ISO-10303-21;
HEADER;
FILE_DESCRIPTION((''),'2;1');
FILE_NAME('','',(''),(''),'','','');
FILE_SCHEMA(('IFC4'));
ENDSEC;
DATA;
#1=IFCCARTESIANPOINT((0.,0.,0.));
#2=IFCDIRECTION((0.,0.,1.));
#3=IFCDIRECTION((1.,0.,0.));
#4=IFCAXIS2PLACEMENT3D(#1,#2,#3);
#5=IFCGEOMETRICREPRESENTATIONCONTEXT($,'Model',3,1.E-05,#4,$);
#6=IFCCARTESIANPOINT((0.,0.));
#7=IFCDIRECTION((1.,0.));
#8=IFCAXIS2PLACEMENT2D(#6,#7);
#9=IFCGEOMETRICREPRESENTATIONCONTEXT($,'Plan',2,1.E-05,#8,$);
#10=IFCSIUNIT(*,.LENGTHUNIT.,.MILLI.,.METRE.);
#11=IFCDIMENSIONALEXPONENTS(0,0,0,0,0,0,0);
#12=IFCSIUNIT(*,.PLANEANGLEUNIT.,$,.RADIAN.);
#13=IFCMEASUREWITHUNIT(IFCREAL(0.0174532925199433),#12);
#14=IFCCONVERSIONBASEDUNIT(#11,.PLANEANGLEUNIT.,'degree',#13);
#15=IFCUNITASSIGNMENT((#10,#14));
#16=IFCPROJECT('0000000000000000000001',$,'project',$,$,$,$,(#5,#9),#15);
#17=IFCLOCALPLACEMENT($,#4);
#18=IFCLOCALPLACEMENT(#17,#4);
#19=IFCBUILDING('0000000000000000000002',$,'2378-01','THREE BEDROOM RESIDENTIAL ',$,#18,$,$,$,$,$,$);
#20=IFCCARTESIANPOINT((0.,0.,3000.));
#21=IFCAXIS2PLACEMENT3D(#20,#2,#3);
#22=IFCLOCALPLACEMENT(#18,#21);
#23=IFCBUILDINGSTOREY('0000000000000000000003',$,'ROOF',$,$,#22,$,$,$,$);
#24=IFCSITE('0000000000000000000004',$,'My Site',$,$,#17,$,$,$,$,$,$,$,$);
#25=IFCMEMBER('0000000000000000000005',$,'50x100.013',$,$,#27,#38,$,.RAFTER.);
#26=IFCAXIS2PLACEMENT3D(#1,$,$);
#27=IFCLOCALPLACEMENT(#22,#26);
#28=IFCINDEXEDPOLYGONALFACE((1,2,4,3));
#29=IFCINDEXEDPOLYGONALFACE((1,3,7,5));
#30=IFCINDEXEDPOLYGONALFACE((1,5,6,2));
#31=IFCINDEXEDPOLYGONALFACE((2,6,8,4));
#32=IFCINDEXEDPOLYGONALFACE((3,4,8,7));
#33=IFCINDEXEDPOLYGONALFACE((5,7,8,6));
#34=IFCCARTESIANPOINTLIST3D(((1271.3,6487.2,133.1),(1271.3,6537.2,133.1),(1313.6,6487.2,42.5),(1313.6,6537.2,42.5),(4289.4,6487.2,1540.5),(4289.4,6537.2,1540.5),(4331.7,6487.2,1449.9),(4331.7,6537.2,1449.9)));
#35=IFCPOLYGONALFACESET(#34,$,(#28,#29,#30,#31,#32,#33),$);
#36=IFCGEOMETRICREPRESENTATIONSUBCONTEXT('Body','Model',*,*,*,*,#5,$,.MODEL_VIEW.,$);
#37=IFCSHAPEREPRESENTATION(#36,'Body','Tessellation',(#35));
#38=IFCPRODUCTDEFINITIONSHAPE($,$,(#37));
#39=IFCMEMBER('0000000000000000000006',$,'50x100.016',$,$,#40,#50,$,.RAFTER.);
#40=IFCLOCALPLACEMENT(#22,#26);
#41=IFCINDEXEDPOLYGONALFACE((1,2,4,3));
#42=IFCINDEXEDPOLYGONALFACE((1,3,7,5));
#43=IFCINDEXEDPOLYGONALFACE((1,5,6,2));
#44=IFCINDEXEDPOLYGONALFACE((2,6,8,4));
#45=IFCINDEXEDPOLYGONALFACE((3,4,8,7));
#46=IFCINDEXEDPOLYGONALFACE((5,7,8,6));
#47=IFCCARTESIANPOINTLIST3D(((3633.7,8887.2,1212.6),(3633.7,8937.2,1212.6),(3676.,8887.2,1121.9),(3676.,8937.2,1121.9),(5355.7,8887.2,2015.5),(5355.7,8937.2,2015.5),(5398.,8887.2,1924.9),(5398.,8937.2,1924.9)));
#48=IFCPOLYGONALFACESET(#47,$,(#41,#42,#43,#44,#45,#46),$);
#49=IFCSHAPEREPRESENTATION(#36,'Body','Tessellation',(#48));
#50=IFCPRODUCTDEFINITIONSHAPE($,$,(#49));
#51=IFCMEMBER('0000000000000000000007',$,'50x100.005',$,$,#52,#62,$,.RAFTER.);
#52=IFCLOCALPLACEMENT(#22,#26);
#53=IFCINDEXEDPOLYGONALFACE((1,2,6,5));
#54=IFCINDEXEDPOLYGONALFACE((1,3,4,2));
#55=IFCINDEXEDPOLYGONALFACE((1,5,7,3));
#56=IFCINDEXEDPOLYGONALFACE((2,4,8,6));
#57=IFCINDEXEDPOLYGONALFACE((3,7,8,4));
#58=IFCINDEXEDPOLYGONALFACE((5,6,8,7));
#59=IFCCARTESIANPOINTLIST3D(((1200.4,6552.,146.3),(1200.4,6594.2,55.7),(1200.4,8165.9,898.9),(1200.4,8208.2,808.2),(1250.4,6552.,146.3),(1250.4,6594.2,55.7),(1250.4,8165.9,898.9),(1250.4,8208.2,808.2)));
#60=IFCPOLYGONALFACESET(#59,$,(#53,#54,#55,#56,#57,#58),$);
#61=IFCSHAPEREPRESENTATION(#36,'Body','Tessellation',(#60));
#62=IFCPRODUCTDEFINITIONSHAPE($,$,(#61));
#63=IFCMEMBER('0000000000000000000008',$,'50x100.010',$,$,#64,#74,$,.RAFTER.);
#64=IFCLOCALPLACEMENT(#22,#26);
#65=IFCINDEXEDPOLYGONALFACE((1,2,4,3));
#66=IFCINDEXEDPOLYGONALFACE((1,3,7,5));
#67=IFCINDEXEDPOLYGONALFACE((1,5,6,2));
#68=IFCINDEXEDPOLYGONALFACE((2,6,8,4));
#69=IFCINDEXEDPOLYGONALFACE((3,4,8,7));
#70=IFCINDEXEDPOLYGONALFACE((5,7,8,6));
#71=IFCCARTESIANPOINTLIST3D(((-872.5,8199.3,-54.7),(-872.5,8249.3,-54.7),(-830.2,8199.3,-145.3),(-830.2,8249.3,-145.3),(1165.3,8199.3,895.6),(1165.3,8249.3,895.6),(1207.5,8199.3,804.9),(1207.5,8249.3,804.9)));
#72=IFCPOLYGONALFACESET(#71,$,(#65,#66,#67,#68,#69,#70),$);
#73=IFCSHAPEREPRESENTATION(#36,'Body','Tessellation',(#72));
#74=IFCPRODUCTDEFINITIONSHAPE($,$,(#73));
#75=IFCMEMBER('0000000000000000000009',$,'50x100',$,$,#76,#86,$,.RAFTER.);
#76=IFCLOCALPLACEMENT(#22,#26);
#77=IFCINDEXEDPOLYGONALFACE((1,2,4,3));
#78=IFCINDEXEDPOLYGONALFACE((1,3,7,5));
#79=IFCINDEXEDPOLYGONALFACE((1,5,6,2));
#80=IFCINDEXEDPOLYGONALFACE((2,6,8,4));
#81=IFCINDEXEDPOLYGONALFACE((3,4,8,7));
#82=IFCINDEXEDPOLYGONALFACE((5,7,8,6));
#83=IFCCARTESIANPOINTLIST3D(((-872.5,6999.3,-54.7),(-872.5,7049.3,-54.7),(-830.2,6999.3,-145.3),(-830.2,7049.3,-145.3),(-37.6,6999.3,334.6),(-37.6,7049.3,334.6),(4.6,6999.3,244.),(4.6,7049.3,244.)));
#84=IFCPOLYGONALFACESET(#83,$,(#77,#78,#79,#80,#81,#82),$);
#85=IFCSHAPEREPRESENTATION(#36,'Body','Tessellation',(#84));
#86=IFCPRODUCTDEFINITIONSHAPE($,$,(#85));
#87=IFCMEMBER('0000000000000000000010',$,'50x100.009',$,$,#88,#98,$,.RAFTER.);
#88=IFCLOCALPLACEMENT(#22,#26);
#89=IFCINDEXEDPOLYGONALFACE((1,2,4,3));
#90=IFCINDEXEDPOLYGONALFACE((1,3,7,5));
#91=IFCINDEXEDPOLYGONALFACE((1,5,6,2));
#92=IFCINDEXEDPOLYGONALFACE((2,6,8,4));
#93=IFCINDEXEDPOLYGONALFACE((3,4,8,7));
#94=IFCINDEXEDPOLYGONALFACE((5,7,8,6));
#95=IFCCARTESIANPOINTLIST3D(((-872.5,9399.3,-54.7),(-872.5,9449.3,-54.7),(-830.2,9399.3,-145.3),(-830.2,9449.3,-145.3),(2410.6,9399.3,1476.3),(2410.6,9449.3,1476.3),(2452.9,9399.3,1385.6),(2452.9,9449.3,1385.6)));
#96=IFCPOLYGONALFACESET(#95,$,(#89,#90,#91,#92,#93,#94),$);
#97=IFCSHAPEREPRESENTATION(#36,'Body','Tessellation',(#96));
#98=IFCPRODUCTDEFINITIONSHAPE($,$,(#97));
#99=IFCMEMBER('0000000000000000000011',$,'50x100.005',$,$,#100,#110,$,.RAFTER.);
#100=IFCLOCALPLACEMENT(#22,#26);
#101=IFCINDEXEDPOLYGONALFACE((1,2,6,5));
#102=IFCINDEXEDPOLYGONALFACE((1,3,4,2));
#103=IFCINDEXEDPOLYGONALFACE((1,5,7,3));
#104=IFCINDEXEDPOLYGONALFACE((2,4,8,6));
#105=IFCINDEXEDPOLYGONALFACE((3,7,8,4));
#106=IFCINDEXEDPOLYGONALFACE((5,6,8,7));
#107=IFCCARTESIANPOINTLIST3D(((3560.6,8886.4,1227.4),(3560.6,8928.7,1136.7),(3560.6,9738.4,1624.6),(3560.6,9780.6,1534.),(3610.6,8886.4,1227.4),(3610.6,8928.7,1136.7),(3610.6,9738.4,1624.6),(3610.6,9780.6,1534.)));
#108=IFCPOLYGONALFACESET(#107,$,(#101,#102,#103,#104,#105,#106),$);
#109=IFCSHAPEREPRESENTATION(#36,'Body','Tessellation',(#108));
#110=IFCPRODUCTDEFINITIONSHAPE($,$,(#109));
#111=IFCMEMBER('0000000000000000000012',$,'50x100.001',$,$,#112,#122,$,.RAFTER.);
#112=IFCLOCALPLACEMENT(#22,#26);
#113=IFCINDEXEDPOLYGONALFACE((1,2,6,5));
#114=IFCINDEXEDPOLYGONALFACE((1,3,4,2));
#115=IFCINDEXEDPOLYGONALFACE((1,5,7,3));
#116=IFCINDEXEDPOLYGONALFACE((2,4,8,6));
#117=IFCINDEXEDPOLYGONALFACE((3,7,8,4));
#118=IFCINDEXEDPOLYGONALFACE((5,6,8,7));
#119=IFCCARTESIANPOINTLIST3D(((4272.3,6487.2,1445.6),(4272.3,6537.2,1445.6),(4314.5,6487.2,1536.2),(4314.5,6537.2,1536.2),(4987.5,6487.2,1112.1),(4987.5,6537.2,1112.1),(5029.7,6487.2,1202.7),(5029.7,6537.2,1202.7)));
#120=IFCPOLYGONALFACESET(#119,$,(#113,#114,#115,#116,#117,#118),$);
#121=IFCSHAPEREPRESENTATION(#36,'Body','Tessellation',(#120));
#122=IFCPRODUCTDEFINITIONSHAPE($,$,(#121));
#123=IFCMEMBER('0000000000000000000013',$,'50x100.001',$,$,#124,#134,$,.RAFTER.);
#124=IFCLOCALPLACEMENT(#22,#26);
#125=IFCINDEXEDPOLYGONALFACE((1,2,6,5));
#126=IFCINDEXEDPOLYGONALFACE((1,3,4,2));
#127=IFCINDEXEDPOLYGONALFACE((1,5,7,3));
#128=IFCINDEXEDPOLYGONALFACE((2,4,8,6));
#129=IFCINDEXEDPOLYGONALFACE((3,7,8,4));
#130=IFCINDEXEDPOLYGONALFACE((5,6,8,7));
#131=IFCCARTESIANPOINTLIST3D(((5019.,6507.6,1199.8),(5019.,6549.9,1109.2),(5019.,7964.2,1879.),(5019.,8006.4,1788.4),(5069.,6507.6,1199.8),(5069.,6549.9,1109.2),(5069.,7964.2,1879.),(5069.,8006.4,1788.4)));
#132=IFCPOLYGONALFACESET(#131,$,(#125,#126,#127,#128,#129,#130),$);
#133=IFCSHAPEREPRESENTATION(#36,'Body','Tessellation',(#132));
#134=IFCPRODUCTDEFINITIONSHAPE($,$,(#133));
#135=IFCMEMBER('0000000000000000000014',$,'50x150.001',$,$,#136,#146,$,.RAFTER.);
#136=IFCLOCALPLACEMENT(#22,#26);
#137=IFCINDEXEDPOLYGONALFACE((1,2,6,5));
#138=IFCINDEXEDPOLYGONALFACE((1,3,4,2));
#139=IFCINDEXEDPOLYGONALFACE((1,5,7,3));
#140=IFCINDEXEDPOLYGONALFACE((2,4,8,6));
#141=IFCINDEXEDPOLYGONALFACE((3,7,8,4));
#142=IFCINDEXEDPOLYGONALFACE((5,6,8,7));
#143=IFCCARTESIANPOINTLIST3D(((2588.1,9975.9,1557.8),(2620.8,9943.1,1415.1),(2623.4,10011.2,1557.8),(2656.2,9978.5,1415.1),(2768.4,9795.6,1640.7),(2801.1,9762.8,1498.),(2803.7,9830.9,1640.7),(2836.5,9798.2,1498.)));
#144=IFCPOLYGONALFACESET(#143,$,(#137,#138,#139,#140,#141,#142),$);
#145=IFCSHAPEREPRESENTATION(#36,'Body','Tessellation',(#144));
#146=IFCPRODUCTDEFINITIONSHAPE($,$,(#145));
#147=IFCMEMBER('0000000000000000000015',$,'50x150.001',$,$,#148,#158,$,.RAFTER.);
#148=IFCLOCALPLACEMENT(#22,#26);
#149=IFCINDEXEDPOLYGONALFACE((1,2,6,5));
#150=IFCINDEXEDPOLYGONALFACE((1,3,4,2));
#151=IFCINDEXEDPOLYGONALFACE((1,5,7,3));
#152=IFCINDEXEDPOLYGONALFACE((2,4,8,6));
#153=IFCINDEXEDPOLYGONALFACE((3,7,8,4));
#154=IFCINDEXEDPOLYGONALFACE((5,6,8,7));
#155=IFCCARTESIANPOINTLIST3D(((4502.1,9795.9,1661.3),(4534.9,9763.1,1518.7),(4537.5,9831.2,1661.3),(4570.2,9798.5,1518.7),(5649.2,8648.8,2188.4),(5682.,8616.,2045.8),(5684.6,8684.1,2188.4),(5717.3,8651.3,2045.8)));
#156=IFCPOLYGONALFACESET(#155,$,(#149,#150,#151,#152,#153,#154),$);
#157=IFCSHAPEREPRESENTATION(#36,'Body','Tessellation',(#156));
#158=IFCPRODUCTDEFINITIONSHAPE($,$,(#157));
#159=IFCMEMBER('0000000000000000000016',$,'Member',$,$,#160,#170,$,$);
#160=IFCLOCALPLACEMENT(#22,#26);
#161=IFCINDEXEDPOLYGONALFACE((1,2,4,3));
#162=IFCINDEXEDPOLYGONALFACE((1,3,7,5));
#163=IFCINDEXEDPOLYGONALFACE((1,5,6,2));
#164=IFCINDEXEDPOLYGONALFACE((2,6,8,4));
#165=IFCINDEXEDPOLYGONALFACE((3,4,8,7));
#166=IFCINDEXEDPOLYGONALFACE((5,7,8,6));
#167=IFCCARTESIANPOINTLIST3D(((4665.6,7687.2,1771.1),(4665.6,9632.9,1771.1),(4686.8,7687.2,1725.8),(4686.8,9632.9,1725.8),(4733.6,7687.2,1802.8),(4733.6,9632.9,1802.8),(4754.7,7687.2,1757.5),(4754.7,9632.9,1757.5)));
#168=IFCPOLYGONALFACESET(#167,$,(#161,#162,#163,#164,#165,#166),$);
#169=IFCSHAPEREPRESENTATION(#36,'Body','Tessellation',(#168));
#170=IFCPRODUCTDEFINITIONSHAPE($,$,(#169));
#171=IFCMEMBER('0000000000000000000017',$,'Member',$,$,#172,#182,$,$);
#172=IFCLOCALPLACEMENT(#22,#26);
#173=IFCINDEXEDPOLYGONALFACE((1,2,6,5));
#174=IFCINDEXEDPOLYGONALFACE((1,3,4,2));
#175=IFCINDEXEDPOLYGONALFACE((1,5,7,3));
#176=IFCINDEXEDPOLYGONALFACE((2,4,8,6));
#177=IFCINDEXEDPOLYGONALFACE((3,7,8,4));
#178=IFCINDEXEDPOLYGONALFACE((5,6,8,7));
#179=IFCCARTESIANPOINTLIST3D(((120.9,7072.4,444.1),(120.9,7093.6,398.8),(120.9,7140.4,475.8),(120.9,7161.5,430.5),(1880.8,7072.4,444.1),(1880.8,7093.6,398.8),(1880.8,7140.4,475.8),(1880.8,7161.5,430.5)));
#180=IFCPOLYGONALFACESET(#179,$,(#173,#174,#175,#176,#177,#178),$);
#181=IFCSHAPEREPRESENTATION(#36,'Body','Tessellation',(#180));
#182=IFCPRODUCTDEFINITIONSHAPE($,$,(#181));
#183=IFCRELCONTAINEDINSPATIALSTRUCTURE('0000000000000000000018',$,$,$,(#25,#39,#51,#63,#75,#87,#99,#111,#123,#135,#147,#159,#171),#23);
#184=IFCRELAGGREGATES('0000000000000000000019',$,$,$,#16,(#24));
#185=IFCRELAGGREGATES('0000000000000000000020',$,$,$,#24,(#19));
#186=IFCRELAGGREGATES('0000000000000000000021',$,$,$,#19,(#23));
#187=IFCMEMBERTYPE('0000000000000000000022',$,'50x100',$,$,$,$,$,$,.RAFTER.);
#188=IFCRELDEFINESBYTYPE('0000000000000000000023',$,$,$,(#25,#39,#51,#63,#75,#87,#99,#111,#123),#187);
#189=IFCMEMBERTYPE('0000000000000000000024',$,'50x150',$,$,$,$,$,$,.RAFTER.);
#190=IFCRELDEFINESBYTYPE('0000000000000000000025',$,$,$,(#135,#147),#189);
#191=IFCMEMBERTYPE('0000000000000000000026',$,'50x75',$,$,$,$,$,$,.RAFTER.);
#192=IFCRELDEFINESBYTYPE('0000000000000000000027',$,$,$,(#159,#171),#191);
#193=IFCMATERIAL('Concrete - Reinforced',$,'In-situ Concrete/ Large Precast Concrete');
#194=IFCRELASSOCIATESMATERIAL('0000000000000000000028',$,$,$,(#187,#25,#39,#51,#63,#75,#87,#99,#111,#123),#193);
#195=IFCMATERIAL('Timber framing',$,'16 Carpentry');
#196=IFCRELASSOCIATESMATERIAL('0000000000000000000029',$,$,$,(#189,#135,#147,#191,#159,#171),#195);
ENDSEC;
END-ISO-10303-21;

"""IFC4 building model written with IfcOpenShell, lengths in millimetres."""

from ifc_helpers import new_model, entity, si_unit, converted_unit, frame, origin_with_axes, origin_2d_with_axis, place, context, subcontext, project, spatial, rectangle, extrude, material, material_profile, profile_set, profile_usage, type_object, element, save


model = new_model("IFC4")

# Units and contexts
model_context = context("Model", 3, precision=1e-05, world=origin_with_axes())
plan_context = context("Plan", 2, precision=1e-05, world=origin_2d_with_axis())
body_context = subcontext(model_context, "Body", "Model", "MODEL_VIEW")
ifc_project = project(units=[si_unit("LENGTHUNIT", "METRE", prefix="MILLI"), converted_unit("PLANEANGLEUNIT", "degree", entity("IfcReal", 0.0174532925199433), si_unit("PLANEANGLEUNIT", "RADIAN"), dimensions=[0, 0, 0, 0, 0, 0, 0])], contexts=[model_context, plan_context])

# Site, building, storey
site_placement = place(None, origin_with_axes())
site = spatial("IfcSite", under=ifc_project, at=site_placement, Name="My Site")
building_placement = place(site_placement, origin_with_axes())
building = spatial("IfcBuilding", under=site, at=building_placement, Name="2378-01", Description="THREE BEDROOM RESIDENTIAL ")
storey_placement = place(building_placement, frame((0.0, 0.0, 3000.0), z_axis=(0.0, 0.0, 1.0), x_axis=(1.0, 0.0, 0.0)))
storey = spatial("IfcBuildingStorey", under=building, at=storey_placement, Name="ROOF")

# Members
ifc_material_1 = material(Name="Concrete - Reinforced", Category="In-situ Concrete/ Large Precast Concrete")
ifc_material_profile_1 = material_profile(ifc_material_1, rectangle(XDim=50.0, YDim=100.0), Name="Core Layer", Category="LoadBearing", Priority=1)
ifc_profile_set_1 = profile_set([ifc_material_profile_1], Name="wood")
ifc_profile_usage_1 = profile_usage(ifc_profile_set_1)
member_type_1 = type_object("IfcMemberType", Name="50x100", PredefinedType="RAFTER", material=ifc_profile_set_1)
member_1_placement = place(storey_placement, frame((1292.4, 6512.2, 87.8), z_axis=(0.906308, 0.0, 0.422618), x_axis=(0.0, 1.0, 0.0)))
element("IfcMember", 1, at=member_1_placement, inside=storey, type_object=member_type_1, material=ifc_profile_usage_1, Name="50x100.013", PredefinedType="RAFTER", context=body_context, shape_type="SweptSolid", body=[
    extrude(rectangle(XDim=50.0, YDim=100.0), origin_with_axes(), (0.0, 0.0, 1.0), 3330.1),
])
ifc_profile_usage_2 = profile_usage(ifc_profile_set_1)
member_2_placement = place(storey_placement, frame((3654.9, 8912.2, 1167.2), z_axis=(0.906308, 0.0, 0.422618), x_axis=(0.0, 1.0, 0.0)))
element("IfcMember", 2, at=member_2_placement, inside=storey, type_object=member_type_1, material=ifc_profile_usage_2, Name="50x100.016", PredefinedType="RAFTER", context=body_context, shape_type="SweptSolid", body=[
    extrude(rectangle(XDim=50.0, YDim=100.0), origin_with_axes(), (0.0, 0.0, 1.0), 1900.0),
])
ifc_profile_usage_3 = profile_usage(ifc_profile_set_1)
member_3_placement = place(storey_placement, frame((1225.4, 6573.1, 101.0), z_axis=(0.0, 0.906308, 0.422618), x_axis=(-1.0, 0.0, 0.0)))
element("IfcMember", 3, at=member_3_placement, inside=storey, type_object=member_type_1, material=ifc_profile_usage_3, Name="50x100.005", PredefinedType="RAFTER", context=body_context, shape_type="SweptSolid", body=[
    extrude(rectangle(XDim=50.0, YDim=100.0), origin_with_axes(), (0.0, 0.0, 1.0), 1780.8),
])
ifc_profile_usage_4 = profile_usage(ifc_profile_set_1)
member_4_placement = place(storey_placement, frame((-851.4, 8224.3, -100.0), z_axis=(0.906308, 0.0, 0.422618), x_axis=(0.0, 1.0, 0.0)))
element("IfcMember", 4, at=member_4_placement, inside=storey, type_object=member_type_1, material=ifc_profile_usage_4, Name="50x100.010", PredefinedType="RAFTER", context=body_context, shape_type="SweptSolid", body=[
    extrude(rectangle(XDim=50.0, YDim=100.0), origin_with_axes(), (0.0, 0.0, 1.0), 2248.4),
])
ifc_profile_usage_5 = profile_usage(ifc_profile_set_1)
member_5_placement = place(storey_placement, frame((-851.4, 7024.3, -100.0), z_axis=(0.906308, 0.0, 0.422618), x_axis=(0.0, 1.0, 0.0)))
element("IfcMember", 5, at=member_5_placement, inside=storey, type_object=member_type_1, material=ifc_profile_usage_5, Name="50x100", PredefinedType="RAFTER", context=body_context, shape_type="SweptSolid", body=[
    extrude(rectangle(XDim=50.0, YDim=100.0), origin_with_axes(), (0.0, 0.0, 1.0), 921.2),
])
ifc_profile_usage_6 = profile_usage(ifc_profile_set_1)
member_6_placement = place(storey_placement, frame((-851.4, 9424.3, -100.0), z_axis=(0.906308, 0.0, 0.422618), x_axis=(0.0, 1.0, 0.0)))
element("IfcMember", 6, at=member_6_placement, inside=storey, type_object=member_type_1, material=ifc_profile_usage_6, Name="50x100.009", PredefinedType="RAFTER", context=body_context, shape_type="SweptSolid", body=[
    extrude(rectangle(XDim=50.0, YDim=100.0), origin_with_axes(), (0.0, 0.0, 1.0), 3622.5),
])
ifc_profile_usage_7 = profile_usage(ifc_profile_set_1)
member_7_placement = place(storey_placement, frame((3585.6, 8907.6, 1182.0), z_axis=(0.0, 0.906308, 0.422618), x_axis=(-1.0, 0.0, 0.0)))
element("IfcMember", 7, at=member_7_placement, inside=storey, type_object=member_type_1, material=ifc_profile_usage_7, Name="50x100.005", PredefinedType="RAFTER", context=body_context, shape_type="SweptSolid", body=[
    extrude(rectangle(XDim=50.0, YDim=100.0), origin_with_axes(), (0.0, 0.0, 1.0), 940.0),
])
ifc_profile_usage_8 = profile_usage(ifc_profile_set_1)
member_8_placement = place(storey_placement, frame((5008.6, 6512.2, 1157.4), z_axis=(-0.906308, 0.0, 0.422618), x_axis=(0.0, -1.0, 0.0)))
element("IfcMember", 8, at=member_8_placement, inside=storey, type_object=member_type_1, material=ifc_profile_usage_8, Name="50x100.001", PredefinedType="RAFTER", context=body_context, shape_type="SweptSolid", body=[
    extrude(rectangle(XDim=50.0, YDim=100.0), origin_with_axes(), (0.0, 0.0, 1.0), 789.1),
])
ifc_profile_usage_9 = profile_usage(ifc_profile_set_1)
member_9_placement = place(storey_placement, frame((5044.0, 6528.8, 1154.5), z_axis=(0.0, 0.906308, 0.422618), x_axis=(-1.0, 0.0, 0.0)))
element("IfcMember", 9, at=member_9_placement, inside=storey, type_object=member_type_1, material=ifc_profile_usage_9, Name="50x100.001", PredefinedType="RAFTER", context=body_context, shape_type="SweptSolid", body=[
    extrude(rectangle(XDim=50.0, YDim=100.0), origin_with_axes(), (0.0, 0.0, 1.0), 1607.1),
])
ifc_material_2 = material(Name="Timber framing", Category="16 Carpentry")
ifc_material_profile_2 = material_profile(ifc_material_2, rectangle(XDim=50.0, YDim=150.0), Name="Lumber", Category="LoadBearing", Priority=1)
ifc_profile_set_2 = profile_set([ifc_material_profile_2], Name="wood")
ifc_profile_usage_10 = profile_usage(ifc_profile_set_2)
member_type_2 = type_object("IfcMemberType", Name="50x150", PredefinedType="RAFTER", material=ifc_profile_set_2)
member_10_placement = place(storey_placement, frame((2622.1, 9977.2, 1486.5), z_axis=(0.672499, -0.672499, 0.309017), x_axis=(0.707107, 0.707107, 0.0)))
element("IfcMember", 10, at=member_10_placement, inside=storey, type_object=member_type_2, material=ifc_profile_usage_10, Name="50x150.001", PredefinedType="RAFTER", context=body_context, shape_type="SweptSolid", body=[
    extrude(rectangle(XDim=50.0, YDim=150.0), origin_with_axes(), (0.0, 0.0, 1.0), 268.1),
])
ifc_profile_usage_11 = profile_usage(ifc_profile_set_2)
member_11_placement = place(storey_placement, frame((4536.2, 9797.2, 1590.0), z_axis=(0.672499, -0.672499, 0.309017), x_axis=(0.707107, 0.707107, 0.0)))
element("IfcMember", 11, at=member_11_placement, inside=storey, type_object=member_type_2, material=ifc_profile_usage_11, Name="50x150.001", PredefinedType="RAFTER", context=body_context, shape_type="SweptSolid", body=[
    extrude(rectangle(XDim=50.0, YDim=150.0), origin_with_axes(), (0.0, 0.0, 1.0), 1705.8),
])
ifc_material_profile_3 = material_profile(ifc_material_2, rectangle(XDim=50.0, YDim=75.0), Name="Lumber2", Category="Substrate", Priority=2)
ifc_profile_set_3 = profile_set([ifc_material_profile_3])
ifc_profile_usage_12 = profile_usage(ifc_profile_set_3, cardinal=5)
member_type_3 = type_object("IfcMemberType", Name="50x75", PredefinedType="RAFTER", material=ifc_profile_set_3)
member_12_placement = place(storey_placement, frame((4710.2, 7687.2, 1764.3), z_axis=(0.0, 1.0, 0.0), x_axis=(-0.422618, 0.0, 0.906308)))
element("IfcMember", 12, at=member_12_placement, inside=storey, type_object=member_type_3, material=ifc_profile_usage_12, Name="Member", context=body_context, shape_type="SweptSolid", body=[
    extrude(rectangle(XDim=50.0, YDim=75.0), origin_with_axes(), (0.0, 0.0, 1.0), 1945.7),
])
ifc_profile_usage_13 = profile_usage(ifc_profile_set_3, cardinal=5)
member_13_placement = place(storey_placement, frame((1880.8, 7117.0, 437.3), z_axis=(-1.0, 0.0, 0.0), x_axis=(0.0, -0.422618, 0.906308)))
element("IfcMember", 13, at=member_13_placement, inside=storey, type_object=member_type_3, material=ifc_profile_usage_13, Name="Member", context=body_context, shape_type="SweptSolid", body=[
    extrude(rectangle(XDim=50.0, YDim=75.0), origin_with_axes(), (0.0, 0.0, 1.0), 1759.9),
])

save(model, "model.ifc")
